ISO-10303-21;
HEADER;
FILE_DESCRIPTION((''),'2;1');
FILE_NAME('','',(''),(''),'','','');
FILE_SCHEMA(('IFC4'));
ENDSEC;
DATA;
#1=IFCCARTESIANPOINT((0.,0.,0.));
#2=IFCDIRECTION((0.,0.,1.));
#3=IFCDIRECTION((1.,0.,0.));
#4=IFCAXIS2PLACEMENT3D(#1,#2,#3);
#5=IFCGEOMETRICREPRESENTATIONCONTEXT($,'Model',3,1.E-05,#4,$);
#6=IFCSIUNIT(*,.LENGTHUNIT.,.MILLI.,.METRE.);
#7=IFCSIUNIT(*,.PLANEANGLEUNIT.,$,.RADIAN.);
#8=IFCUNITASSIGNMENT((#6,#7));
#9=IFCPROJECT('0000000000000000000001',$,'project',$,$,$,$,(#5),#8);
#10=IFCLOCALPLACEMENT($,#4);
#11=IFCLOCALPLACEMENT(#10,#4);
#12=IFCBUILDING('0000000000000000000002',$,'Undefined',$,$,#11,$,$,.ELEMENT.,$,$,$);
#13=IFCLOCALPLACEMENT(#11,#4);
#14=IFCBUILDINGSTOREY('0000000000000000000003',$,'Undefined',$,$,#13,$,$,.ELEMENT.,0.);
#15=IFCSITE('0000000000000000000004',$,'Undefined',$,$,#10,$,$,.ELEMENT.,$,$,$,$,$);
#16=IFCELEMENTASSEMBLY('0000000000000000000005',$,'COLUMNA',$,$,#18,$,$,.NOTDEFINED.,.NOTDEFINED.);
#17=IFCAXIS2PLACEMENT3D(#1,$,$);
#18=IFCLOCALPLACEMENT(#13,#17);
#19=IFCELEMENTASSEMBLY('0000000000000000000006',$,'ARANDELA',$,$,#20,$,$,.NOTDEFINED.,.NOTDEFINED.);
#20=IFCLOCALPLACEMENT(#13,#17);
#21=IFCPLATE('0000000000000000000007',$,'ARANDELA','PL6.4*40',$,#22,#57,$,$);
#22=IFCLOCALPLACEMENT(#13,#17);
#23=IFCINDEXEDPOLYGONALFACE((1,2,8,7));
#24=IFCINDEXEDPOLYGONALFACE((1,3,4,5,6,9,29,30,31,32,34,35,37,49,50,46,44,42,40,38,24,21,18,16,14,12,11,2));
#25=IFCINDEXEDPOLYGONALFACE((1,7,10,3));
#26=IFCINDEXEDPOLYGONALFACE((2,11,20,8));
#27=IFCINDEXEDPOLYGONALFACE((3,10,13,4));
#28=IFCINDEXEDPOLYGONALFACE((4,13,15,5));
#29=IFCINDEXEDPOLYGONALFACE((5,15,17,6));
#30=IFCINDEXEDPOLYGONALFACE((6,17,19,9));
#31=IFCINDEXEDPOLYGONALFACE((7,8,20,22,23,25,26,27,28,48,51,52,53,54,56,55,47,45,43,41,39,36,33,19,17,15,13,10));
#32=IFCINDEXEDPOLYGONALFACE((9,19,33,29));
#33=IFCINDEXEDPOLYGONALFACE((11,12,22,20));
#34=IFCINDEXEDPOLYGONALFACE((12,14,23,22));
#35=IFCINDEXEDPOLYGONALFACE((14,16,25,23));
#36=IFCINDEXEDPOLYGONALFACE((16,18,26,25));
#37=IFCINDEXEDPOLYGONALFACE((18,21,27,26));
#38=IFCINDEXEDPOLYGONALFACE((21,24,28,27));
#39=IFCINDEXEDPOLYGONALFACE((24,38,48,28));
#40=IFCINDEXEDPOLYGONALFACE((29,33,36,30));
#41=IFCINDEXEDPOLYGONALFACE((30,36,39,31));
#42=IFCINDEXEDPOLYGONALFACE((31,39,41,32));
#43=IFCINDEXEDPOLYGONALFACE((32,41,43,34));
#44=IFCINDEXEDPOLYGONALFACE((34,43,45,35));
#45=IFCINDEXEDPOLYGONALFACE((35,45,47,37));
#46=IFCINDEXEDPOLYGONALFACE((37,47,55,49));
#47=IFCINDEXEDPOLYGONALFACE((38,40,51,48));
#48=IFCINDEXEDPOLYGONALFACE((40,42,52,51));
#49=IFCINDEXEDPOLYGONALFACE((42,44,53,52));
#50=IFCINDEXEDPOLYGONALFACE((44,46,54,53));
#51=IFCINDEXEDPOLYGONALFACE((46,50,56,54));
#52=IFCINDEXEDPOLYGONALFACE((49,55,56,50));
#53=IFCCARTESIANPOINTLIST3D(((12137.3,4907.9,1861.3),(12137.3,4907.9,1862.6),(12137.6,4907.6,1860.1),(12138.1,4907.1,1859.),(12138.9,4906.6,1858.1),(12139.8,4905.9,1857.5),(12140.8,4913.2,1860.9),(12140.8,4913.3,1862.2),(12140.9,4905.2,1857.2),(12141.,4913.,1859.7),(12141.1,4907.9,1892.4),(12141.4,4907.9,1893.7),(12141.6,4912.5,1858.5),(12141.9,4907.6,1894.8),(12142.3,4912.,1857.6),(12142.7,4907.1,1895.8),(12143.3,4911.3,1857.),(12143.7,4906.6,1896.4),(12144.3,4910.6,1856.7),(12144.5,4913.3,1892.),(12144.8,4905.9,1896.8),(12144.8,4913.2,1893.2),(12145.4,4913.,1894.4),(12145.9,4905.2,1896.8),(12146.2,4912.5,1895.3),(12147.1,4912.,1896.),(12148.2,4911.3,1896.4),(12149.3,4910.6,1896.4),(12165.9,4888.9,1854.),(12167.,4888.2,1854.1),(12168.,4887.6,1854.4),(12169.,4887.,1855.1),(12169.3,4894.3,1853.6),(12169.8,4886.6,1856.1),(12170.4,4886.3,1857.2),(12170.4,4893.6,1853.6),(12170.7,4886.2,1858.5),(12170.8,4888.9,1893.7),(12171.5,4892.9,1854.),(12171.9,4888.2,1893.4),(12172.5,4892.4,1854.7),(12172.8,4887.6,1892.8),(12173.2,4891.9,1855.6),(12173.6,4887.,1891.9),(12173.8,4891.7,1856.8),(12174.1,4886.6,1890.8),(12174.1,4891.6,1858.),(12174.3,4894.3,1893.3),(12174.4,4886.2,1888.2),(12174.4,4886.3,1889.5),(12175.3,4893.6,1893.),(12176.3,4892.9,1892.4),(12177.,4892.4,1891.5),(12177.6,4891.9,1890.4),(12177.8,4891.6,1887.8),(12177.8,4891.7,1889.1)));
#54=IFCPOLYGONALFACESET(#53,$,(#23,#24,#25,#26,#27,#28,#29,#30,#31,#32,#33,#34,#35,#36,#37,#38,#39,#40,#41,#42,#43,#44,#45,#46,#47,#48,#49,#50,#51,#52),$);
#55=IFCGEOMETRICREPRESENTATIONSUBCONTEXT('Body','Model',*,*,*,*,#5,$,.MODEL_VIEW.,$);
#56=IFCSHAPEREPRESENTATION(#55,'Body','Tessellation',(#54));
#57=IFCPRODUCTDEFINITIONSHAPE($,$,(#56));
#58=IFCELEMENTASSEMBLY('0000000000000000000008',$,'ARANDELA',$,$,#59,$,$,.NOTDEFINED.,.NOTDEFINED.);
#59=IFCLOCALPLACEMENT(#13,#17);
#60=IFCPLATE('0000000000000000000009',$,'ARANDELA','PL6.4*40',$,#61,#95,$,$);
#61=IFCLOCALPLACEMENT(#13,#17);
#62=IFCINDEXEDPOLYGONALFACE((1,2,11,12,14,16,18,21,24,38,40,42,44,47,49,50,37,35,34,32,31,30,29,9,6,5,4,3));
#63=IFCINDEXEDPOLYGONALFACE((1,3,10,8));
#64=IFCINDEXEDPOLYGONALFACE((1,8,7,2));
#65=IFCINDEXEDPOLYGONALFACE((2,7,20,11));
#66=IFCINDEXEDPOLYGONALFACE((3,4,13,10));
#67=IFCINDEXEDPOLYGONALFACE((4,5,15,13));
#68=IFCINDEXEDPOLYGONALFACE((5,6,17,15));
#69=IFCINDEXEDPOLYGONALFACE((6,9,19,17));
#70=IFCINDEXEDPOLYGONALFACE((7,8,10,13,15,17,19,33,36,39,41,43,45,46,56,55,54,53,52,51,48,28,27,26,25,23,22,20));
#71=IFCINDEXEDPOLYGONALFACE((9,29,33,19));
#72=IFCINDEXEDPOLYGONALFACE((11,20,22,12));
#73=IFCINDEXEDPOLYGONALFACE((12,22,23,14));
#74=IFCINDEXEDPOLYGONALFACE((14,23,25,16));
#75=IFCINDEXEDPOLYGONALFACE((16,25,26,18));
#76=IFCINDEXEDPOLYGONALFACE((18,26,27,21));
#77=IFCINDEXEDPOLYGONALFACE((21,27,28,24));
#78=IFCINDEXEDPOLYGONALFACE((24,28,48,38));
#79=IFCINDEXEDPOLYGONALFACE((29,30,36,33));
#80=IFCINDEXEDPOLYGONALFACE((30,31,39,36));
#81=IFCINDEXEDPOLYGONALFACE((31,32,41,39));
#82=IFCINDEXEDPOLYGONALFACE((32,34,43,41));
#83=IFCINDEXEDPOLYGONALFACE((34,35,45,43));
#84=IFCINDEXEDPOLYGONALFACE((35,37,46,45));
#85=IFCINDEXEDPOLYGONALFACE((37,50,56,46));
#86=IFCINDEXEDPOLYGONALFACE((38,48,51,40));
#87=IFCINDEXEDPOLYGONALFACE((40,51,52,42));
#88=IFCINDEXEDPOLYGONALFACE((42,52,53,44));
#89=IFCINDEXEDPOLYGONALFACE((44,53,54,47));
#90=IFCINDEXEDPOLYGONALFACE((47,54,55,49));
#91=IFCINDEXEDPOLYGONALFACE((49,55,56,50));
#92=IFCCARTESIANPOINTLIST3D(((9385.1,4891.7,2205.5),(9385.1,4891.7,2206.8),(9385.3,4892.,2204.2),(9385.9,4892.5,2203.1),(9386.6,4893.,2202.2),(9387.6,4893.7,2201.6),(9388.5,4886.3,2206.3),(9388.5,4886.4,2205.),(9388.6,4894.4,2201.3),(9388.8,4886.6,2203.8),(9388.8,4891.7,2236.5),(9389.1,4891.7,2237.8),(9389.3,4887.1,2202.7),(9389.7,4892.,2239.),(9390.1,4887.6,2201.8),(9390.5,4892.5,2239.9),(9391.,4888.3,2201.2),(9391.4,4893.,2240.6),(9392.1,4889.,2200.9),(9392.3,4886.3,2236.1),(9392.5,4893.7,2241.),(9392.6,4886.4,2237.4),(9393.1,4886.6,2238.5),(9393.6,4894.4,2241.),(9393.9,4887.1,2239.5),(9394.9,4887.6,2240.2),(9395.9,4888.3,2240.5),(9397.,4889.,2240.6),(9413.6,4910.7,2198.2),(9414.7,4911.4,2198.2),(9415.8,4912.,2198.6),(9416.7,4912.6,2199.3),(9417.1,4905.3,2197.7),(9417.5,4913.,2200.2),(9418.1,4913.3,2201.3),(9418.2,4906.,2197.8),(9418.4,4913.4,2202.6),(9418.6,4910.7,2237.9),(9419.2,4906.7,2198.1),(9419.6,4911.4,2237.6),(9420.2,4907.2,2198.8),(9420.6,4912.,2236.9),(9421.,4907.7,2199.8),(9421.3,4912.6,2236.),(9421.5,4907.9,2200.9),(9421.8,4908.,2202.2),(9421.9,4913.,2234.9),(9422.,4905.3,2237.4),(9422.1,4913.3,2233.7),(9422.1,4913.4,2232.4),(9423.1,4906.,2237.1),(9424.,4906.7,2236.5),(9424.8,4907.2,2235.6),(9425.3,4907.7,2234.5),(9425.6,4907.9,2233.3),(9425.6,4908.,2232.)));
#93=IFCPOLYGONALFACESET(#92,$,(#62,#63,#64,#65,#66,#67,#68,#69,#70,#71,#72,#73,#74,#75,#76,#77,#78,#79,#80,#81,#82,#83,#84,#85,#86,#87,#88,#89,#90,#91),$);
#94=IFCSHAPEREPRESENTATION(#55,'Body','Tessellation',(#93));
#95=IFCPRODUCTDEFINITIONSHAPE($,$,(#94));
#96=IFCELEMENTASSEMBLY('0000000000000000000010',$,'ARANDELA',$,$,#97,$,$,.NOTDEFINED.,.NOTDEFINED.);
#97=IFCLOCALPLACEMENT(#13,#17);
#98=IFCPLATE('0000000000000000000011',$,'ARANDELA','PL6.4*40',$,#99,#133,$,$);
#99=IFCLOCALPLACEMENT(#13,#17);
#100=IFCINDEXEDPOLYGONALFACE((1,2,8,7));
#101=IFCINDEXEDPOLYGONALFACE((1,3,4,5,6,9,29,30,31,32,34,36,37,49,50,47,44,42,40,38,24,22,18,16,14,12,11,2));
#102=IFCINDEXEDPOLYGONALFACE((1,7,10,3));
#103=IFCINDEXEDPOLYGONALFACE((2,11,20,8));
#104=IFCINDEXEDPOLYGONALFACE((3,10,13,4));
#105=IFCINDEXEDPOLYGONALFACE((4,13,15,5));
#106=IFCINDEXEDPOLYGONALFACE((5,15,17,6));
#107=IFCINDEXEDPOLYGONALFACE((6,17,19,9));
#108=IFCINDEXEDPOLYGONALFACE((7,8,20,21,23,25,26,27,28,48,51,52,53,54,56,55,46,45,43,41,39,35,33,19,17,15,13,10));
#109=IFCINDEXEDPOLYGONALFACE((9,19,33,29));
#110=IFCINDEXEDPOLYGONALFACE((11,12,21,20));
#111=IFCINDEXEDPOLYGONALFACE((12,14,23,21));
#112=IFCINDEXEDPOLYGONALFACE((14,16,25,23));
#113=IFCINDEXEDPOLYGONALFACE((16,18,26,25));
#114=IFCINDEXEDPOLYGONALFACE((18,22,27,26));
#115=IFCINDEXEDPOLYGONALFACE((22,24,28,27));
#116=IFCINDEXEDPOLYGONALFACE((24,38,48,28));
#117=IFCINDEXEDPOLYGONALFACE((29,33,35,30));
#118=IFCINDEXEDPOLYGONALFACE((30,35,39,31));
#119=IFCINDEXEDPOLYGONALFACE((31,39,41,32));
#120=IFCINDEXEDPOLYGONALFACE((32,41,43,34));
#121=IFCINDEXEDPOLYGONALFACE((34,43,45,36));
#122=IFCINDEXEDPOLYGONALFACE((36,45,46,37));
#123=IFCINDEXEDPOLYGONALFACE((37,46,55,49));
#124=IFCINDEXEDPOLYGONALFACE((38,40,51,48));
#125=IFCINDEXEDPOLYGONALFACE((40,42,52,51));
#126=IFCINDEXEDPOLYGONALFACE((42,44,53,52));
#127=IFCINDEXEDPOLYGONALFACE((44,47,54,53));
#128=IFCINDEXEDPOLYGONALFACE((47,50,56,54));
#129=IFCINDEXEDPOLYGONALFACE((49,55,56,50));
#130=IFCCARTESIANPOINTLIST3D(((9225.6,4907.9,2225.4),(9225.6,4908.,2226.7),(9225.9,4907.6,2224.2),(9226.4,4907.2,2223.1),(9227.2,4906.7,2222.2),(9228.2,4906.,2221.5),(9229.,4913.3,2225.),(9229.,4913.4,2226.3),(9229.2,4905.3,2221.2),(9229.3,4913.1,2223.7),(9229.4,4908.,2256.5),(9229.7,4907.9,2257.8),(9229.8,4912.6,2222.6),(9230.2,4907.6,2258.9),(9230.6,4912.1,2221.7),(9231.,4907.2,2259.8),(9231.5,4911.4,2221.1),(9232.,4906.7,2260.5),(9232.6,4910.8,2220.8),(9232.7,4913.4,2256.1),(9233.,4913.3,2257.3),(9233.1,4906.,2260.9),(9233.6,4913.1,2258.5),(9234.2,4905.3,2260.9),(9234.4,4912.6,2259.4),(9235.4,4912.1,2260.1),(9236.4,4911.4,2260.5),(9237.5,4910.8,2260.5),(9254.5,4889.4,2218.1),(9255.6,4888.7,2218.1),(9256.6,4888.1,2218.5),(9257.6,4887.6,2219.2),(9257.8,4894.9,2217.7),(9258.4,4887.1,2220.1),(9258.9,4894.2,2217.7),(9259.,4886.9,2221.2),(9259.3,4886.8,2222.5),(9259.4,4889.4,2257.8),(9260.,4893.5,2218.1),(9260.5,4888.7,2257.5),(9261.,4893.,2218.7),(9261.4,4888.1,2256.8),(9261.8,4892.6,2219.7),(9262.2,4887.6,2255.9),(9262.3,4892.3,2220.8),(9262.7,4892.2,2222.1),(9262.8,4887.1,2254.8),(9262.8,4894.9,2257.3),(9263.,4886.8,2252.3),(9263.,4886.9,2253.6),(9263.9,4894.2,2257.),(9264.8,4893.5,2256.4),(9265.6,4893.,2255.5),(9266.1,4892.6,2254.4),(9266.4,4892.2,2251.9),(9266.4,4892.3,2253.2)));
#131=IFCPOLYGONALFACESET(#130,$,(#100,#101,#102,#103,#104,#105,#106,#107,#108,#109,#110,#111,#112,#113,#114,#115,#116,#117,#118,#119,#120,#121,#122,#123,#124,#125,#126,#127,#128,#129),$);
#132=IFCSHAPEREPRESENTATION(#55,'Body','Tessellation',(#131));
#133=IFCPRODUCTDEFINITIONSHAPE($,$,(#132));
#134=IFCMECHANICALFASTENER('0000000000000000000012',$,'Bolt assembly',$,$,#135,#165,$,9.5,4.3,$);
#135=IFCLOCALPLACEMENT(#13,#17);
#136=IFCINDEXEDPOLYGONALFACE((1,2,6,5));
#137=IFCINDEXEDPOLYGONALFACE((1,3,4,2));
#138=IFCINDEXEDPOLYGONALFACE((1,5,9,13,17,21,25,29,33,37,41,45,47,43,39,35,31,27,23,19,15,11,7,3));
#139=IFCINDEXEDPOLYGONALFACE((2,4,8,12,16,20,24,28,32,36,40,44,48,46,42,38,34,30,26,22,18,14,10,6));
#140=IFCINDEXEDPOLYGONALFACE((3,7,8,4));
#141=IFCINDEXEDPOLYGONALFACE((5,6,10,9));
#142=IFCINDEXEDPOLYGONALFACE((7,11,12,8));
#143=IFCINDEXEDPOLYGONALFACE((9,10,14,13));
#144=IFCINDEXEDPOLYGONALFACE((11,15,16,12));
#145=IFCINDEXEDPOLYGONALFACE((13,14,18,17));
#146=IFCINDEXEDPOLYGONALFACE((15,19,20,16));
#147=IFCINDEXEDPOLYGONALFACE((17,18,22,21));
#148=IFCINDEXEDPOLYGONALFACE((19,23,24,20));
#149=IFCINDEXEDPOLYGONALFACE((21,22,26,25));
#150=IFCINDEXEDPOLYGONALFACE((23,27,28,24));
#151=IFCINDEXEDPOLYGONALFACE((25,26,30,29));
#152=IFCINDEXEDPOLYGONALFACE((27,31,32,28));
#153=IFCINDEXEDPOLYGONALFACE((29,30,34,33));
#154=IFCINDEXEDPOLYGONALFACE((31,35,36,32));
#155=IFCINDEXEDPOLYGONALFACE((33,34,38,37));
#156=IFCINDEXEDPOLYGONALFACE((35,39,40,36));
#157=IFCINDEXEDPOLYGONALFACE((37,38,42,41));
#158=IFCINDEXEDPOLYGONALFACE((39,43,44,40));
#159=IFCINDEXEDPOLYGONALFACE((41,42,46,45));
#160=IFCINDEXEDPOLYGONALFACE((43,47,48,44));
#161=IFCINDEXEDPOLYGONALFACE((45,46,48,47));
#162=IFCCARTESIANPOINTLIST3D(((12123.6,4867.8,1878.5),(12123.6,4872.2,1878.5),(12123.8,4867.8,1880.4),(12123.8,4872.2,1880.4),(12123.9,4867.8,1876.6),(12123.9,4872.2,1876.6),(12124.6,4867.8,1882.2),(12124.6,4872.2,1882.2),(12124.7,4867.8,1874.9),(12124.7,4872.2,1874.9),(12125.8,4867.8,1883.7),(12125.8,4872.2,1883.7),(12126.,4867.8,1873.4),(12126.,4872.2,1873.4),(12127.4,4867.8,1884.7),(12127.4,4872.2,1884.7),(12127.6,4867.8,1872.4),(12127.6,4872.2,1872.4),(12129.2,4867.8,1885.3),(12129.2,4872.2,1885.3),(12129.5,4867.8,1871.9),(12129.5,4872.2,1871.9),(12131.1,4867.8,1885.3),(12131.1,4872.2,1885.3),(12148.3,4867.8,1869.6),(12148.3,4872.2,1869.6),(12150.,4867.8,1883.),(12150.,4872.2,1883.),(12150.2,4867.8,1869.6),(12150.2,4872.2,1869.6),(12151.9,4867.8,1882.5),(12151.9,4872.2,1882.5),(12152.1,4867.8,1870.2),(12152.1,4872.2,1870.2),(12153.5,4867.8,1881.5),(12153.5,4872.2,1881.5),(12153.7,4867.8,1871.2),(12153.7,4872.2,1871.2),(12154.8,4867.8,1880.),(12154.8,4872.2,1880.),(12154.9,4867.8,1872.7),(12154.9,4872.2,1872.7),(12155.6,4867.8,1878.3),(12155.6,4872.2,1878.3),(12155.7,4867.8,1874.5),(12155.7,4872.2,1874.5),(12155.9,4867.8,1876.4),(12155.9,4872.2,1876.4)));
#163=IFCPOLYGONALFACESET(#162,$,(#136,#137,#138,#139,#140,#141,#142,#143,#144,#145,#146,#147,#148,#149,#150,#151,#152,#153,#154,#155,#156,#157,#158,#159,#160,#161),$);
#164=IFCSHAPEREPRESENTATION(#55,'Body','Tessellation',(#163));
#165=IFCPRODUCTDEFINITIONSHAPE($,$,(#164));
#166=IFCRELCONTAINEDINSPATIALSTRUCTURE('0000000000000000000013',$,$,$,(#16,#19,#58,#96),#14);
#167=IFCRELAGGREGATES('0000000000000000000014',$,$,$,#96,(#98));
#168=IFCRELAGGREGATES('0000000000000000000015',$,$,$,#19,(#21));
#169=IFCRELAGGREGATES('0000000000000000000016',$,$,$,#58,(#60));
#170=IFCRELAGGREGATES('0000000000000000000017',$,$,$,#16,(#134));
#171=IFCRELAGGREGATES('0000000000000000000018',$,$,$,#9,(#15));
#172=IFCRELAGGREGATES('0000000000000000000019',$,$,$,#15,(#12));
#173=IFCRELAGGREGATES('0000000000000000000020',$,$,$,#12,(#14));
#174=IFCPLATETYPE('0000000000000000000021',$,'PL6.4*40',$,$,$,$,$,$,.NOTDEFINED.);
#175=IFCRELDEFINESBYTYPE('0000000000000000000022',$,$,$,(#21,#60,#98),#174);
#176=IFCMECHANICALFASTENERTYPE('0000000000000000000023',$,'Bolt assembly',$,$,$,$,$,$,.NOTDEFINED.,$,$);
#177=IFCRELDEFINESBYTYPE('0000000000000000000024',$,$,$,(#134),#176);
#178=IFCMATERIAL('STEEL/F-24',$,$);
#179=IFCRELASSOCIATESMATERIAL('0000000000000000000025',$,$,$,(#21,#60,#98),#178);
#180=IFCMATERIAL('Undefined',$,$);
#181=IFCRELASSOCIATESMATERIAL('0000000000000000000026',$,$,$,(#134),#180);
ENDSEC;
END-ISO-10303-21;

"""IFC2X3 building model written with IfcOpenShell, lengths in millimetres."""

from ifc_helpers import new_model, si_unit, frame, frame_2d, origin_with_axes, place, context, subcontext, project, spatial, polyline, circle_curve, parameter, trimmed, segment, composite_curve, outline, extrude, source, transform, mapped, material, type_object, element, aggregate, save


model = new_model("IFC2X3")

# Units and contexts
model_context = context("Model", 3, precision=1e-05, world=origin_with_axes())
body_context = subcontext(model_context, "Body", "Model", "MODEL_VIEW")
ifc_project = project(units=[si_unit("LENGTHUNIT", "METRE", prefix="MILLI"), si_unit("PLANEANGLEUNIT", "RADIAN")], contexts=[model_context])

# Site, building, storey
site_placement = place(None, origin_with_axes())
site = spatial("IfcSite", under=ifc_project, at=site_placement, Name="Undefined", CompositionType="ELEMENT")
building_placement = place(site_placement, origin_with_axes())
building = spatial("IfcBuilding", under=site, at=building_placement, Name="Undefined", CompositionType="ELEMENT")
storey_placement = place(building_placement, origin_with_axes())
storey = spatial("IfcBuildingStorey", under=building, at=storey_placement, Name="Undefined", CompositionType="ELEMENT", Elevation=0.0)

# Shared definitions
ifc_material_1 = material(Name="STEEL/F-24")

# Element assembly
assembly_1_placement = place(storey_placement, origin_with_axes())
assembly_1 = element("IfcElementAssembly", 1, at=assembly_1_placement, inside=storey, Name="COLUMNA", AssemblyPlace="NOTDEFINED", PredefinedType="NOTDEFINED")

# Element assemblies, plates
assembly_2_placement = place(storey_placement, origin_with_axes())
assembly_2 = element("IfcElementAssembly", 2, at=assembly_2_placement, inside=storey, Name="ARANDELA", AssemblyPlace="NOTDEFINED", PredefinedType="NOTDEFINED")
plate_type_1 = type_object("IfcPlateType", Name="PL6.4*40", PredefinedType="NOTDEFINED")
plate_1_placement = place(assembly_2_placement, frame((12176.7, 4888.9, 1893.0), z_axis=(-0.539678, -0.839163, 0.067482), x_axis=(-0.832679, 0.54388, 0.104119)))
plate_1 = element("IfcPlate", 3, at=plate_1_placement, type_object=plate_type_1, material=ifc_material_1, Name="ARANDELA", Description="PL6.4*40", context=body_context, shape_type="SweptSolid", body=[
    extrude(outline(composite_curve([segment(trimmed(circle_curve(frame_2d((5.0, 5.0), x_axis=(-1.0, 0.0)), 5.0), [parameter(0.0)], [parameter(1.570796)], True, "PARAMETER"), True, "CONTINUOUS"), segment(polyline([(5.0, 0.0), (35.0, 0.0)]), True, "CONTINUOUS"), segment(trimmed(circle_curve(frame_2d((35.0, 5.0), x_axis=(0.0, -1.0)), 5.0), [parameter(0.0)], [parameter(1.570796)], True, "PARAMETER"), True, "CONTINUOUS"), segment(polyline([(40.0, 5.0), (40.0, 35.0)]), True, "CONTINUOUS"), segment(trimmed(circle_curve(frame_2d((35.0, 35.0), x_axis=(1.0, 0.0)), 5.0), [parameter(0.0)], [parameter(1.570796)], True, "PARAMETER"), True, "CONTINUOUS"), segment(polyline([(35.0, 40.0), (5.0, 40.0)]), True, "CONTINUOUS"), segment(trimmed(circle_curve(frame_2d((5.0, 35.0), x_axis=(0.0, 1.0)), 5.0), [parameter(0.0)], [parameter(1.570796)], True, "PARAMETER"), True, "CONTINUOUS"), segment(polyline([(0.0, 35.0), (0.0, 5.0)]), True, "CONTINUOUS")], self_intersect=True)), frame((0.0, 0.0, -3.2), z_axis=(0.0, 0.0, 1.0), x_axis=(1.0, 0.0, 0.0)), (0.0, 0.0, 1.0), 6.4),
])
assembly_3_placement = place(storey_placement, origin_with_axes())
assembly_3 = element("IfcElementAssembly", 4, at=assembly_3_placement, inside=storey, Name="ARANDELA", AssemblyPlace="NOTDEFINED", PredefinedType="NOTDEFINED")
plate_2_placement = place(assembly_3_placement, frame((9424.5, 4910.7, 2237.1), z_axis=(0.539678, -0.839163, -0.067482), x_axis=(-0.832679, -0.54388, 0.104119)))
plate_2 = element("IfcPlate", 5, at=plate_2_placement, type_object=plate_type_1, material=ifc_material_1, Name="ARANDELA", Description="PL6.4*40", context=body_context, shape_type="SweptSolid", body=[
    extrude(outline(composite_curve([segment(trimmed(circle_curve(frame_2d((5.0, 5.0), x_axis=(-1.0, 0.0)), 5.0), [parameter(0.0)], [parameter(1.570796)], True, "PARAMETER"), True, "CONTINUOUS"), segment(polyline([(5.0, 0.0), (35.0, 0.0)]), True, "CONTINUOUS"), segment(trimmed(circle_curve(frame_2d((35.0, 5.0), x_axis=(0.0, -1.0)), 5.0), [parameter(0.0)], [parameter(1.570796)], True, "PARAMETER"), True, "CONTINUOUS"), segment(polyline([(40.0, 5.0), (40.0, 35.0)]), True, "CONTINUOUS"), segment(trimmed(circle_curve(frame_2d((35.0, 35.0), x_axis=(1.0, 0.0)), 5.0), [parameter(0.0)], [parameter(1.570796)], True, "PARAMETER"), True, "CONTINUOUS"), segment(polyline([(35.0, 40.0), (5.0, 40.0)]), True, "CONTINUOUS"), segment(trimmed(circle_curve(frame_2d((5.0, 35.0), x_axis=(0.0, 1.0)), 5.0), [parameter(0.0)], [parameter(1.570796)], True, "PARAMETER"), True, "CONTINUOUS"), segment(polyline([(0.0, 35.0), (0.0, 5.0)]), True, "CONTINUOUS")], self_intersect=True)), frame((0.0, 0.0, -3.2), z_axis=(0.0, 0.0, 1.0), x_axis=(1.0, 0.0, 0.0)), (0.0, 0.0, 1.0), 6.4),
])
assembly_4_placement = place(storey_placement, origin_with_axes())
assembly_4 = element("IfcElementAssembly", 6, at=assembly_4_placement, inside=storey, Name="ARANDELA", AssemblyPlace="NOTDEFINED", PredefinedType="NOTDEFINED")
plate_3_placement = place(assembly_4_placement, frame((9265.3, 4889.5, 2257.0), z_axis=(-0.526076, -0.84789, 0.065781), x_axis=(-0.841338, 0.530172, 0.105202)))
plate_3 = element("IfcPlate", 7, at=plate_3_placement, type_object=plate_type_1, material=ifc_material_1, Name="ARANDELA", Description="PL6.4*40", context=body_context, shape_type="SweptSolid", body=[
    extrude(outline(composite_curve([segment(trimmed(circle_curve(frame_2d((5.0, 5.0), x_axis=(-1.0, 0.0)), 5.0), [parameter(0.0)], [parameter(1.570796)], True, "PARAMETER"), True, "CONTINUOUS"), segment(polyline([(5.0, 0.0), (35.0, 0.0)]), True, "CONTINUOUS"), segment(trimmed(circle_curve(frame_2d((35.0, 5.0), x_axis=(0.0, -1.0)), 5.0), [parameter(0.0)], [parameter(1.570796)], True, "PARAMETER"), True, "CONTINUOUS"), segment(polyline([(40.0, 5.0), (40.0, 35.0)]), True, "CONTINUOUS"), segment(trimmed(circle_curve(frame_2d((35.0, 35.0), x_axis=(1.0, 0.0)), 5.0), [parameter(0.0)], [parameter(1.570796)], True, "PARAMETER"), True, "CONTINUOUS"), segment(polyline([(35.0, 40.0), (5.0, 40.0)]), True, "CONTINUOUS"), segment(trimmed(circle_curve(frame_2d((5.0, 35.0), x_axis=(0.0, 1.0)), 5.0), [parameter(0.0)], [parameter(1.570796)], True, "PARAMETER"), True, "CONTINUOUS"), segment(polyline([(0.0, 35.0), (0.0, 5.0)]), True, "CONTINUOUS")], self_intersect=True)), frame((0.0, 0.0, -3.2), z_axis=(0.0, 0.0, 1.0), x_axis=(1.0, 0.0, 0.0)), (0.0, 0.0, 1.0), 6.4),
])
aggregate(assembly_4, [plate_3])

# Mechanical fastener
ifc_material_2 = material(Name="Undefined")
mechanical_fastener_type = type_object("IfcMechanicalFastenerType", Name="Bolt assembly")
shared_shape_1 = source(origin_with_axes(), body_context, "Body", "SweptSolid", [
    extrude(outline(composite_curve([segment(polyline([(-9.5, 6.8), (9.5, 6.8)]), True, "CONTINUOUS"), segment(trimmed(circle_curve(frame_2d((9.5, 0.0), x_axis=(0.0, 1.0)), 6.8), [parameter(0.0)], [parameter(3.141593)], False, "PARAMETER"), True, "CONTINUOUS"), segment(polyline([(9.5, -6.8), (-9.5, -6.8)]), True, "CONTINUOUS"), segment(trimmed(circle_curve(frame_2d((-9.5, 0.0), x_axis=(0.0, -1.0)), 6.8), [parameter(0.0)], [parameter(3.141593)], False, "PARAMETER"), True, "DISCONTINUOUS")], self_intersect=False)), frame((0.0, 0.0, 0.0), z_axis=(0.0, 1.0, 0.0), x_axis=(1.0, 0.0, 0.0)), (0.0, 0.0, 1.0), 4.4),
])
mechanical_fastener_1_placement = place(assembly_1_placement, frame((12139.7, 4872.2, 1877.5), z_axis=(-0.124075, 0.0, -0.992273), x_axis=(0.992273, 0.0, -0.124075)))
mechanical_fastener_1 = element("IfcMechanicalFastener", 8, at=mechanical_fastener_1_placement, type_object=mechanical_fastener_type, material=ifc_material_2, Name="Bolt assembly", NominalDiameter=9.5, NominalLength=4.3, context=body_context, shape_type="MappedRepresentation", body=[
    mapped(shared_shape_1, transform((0.0, 0.0, 0.0))),
])
aggregate(assembly_2, [plate_1])
aggregate(assembly_3, [plate_2])

aggregate(assembly_1, [mechanical_fastener_1])

save(model, "model.ifc")
